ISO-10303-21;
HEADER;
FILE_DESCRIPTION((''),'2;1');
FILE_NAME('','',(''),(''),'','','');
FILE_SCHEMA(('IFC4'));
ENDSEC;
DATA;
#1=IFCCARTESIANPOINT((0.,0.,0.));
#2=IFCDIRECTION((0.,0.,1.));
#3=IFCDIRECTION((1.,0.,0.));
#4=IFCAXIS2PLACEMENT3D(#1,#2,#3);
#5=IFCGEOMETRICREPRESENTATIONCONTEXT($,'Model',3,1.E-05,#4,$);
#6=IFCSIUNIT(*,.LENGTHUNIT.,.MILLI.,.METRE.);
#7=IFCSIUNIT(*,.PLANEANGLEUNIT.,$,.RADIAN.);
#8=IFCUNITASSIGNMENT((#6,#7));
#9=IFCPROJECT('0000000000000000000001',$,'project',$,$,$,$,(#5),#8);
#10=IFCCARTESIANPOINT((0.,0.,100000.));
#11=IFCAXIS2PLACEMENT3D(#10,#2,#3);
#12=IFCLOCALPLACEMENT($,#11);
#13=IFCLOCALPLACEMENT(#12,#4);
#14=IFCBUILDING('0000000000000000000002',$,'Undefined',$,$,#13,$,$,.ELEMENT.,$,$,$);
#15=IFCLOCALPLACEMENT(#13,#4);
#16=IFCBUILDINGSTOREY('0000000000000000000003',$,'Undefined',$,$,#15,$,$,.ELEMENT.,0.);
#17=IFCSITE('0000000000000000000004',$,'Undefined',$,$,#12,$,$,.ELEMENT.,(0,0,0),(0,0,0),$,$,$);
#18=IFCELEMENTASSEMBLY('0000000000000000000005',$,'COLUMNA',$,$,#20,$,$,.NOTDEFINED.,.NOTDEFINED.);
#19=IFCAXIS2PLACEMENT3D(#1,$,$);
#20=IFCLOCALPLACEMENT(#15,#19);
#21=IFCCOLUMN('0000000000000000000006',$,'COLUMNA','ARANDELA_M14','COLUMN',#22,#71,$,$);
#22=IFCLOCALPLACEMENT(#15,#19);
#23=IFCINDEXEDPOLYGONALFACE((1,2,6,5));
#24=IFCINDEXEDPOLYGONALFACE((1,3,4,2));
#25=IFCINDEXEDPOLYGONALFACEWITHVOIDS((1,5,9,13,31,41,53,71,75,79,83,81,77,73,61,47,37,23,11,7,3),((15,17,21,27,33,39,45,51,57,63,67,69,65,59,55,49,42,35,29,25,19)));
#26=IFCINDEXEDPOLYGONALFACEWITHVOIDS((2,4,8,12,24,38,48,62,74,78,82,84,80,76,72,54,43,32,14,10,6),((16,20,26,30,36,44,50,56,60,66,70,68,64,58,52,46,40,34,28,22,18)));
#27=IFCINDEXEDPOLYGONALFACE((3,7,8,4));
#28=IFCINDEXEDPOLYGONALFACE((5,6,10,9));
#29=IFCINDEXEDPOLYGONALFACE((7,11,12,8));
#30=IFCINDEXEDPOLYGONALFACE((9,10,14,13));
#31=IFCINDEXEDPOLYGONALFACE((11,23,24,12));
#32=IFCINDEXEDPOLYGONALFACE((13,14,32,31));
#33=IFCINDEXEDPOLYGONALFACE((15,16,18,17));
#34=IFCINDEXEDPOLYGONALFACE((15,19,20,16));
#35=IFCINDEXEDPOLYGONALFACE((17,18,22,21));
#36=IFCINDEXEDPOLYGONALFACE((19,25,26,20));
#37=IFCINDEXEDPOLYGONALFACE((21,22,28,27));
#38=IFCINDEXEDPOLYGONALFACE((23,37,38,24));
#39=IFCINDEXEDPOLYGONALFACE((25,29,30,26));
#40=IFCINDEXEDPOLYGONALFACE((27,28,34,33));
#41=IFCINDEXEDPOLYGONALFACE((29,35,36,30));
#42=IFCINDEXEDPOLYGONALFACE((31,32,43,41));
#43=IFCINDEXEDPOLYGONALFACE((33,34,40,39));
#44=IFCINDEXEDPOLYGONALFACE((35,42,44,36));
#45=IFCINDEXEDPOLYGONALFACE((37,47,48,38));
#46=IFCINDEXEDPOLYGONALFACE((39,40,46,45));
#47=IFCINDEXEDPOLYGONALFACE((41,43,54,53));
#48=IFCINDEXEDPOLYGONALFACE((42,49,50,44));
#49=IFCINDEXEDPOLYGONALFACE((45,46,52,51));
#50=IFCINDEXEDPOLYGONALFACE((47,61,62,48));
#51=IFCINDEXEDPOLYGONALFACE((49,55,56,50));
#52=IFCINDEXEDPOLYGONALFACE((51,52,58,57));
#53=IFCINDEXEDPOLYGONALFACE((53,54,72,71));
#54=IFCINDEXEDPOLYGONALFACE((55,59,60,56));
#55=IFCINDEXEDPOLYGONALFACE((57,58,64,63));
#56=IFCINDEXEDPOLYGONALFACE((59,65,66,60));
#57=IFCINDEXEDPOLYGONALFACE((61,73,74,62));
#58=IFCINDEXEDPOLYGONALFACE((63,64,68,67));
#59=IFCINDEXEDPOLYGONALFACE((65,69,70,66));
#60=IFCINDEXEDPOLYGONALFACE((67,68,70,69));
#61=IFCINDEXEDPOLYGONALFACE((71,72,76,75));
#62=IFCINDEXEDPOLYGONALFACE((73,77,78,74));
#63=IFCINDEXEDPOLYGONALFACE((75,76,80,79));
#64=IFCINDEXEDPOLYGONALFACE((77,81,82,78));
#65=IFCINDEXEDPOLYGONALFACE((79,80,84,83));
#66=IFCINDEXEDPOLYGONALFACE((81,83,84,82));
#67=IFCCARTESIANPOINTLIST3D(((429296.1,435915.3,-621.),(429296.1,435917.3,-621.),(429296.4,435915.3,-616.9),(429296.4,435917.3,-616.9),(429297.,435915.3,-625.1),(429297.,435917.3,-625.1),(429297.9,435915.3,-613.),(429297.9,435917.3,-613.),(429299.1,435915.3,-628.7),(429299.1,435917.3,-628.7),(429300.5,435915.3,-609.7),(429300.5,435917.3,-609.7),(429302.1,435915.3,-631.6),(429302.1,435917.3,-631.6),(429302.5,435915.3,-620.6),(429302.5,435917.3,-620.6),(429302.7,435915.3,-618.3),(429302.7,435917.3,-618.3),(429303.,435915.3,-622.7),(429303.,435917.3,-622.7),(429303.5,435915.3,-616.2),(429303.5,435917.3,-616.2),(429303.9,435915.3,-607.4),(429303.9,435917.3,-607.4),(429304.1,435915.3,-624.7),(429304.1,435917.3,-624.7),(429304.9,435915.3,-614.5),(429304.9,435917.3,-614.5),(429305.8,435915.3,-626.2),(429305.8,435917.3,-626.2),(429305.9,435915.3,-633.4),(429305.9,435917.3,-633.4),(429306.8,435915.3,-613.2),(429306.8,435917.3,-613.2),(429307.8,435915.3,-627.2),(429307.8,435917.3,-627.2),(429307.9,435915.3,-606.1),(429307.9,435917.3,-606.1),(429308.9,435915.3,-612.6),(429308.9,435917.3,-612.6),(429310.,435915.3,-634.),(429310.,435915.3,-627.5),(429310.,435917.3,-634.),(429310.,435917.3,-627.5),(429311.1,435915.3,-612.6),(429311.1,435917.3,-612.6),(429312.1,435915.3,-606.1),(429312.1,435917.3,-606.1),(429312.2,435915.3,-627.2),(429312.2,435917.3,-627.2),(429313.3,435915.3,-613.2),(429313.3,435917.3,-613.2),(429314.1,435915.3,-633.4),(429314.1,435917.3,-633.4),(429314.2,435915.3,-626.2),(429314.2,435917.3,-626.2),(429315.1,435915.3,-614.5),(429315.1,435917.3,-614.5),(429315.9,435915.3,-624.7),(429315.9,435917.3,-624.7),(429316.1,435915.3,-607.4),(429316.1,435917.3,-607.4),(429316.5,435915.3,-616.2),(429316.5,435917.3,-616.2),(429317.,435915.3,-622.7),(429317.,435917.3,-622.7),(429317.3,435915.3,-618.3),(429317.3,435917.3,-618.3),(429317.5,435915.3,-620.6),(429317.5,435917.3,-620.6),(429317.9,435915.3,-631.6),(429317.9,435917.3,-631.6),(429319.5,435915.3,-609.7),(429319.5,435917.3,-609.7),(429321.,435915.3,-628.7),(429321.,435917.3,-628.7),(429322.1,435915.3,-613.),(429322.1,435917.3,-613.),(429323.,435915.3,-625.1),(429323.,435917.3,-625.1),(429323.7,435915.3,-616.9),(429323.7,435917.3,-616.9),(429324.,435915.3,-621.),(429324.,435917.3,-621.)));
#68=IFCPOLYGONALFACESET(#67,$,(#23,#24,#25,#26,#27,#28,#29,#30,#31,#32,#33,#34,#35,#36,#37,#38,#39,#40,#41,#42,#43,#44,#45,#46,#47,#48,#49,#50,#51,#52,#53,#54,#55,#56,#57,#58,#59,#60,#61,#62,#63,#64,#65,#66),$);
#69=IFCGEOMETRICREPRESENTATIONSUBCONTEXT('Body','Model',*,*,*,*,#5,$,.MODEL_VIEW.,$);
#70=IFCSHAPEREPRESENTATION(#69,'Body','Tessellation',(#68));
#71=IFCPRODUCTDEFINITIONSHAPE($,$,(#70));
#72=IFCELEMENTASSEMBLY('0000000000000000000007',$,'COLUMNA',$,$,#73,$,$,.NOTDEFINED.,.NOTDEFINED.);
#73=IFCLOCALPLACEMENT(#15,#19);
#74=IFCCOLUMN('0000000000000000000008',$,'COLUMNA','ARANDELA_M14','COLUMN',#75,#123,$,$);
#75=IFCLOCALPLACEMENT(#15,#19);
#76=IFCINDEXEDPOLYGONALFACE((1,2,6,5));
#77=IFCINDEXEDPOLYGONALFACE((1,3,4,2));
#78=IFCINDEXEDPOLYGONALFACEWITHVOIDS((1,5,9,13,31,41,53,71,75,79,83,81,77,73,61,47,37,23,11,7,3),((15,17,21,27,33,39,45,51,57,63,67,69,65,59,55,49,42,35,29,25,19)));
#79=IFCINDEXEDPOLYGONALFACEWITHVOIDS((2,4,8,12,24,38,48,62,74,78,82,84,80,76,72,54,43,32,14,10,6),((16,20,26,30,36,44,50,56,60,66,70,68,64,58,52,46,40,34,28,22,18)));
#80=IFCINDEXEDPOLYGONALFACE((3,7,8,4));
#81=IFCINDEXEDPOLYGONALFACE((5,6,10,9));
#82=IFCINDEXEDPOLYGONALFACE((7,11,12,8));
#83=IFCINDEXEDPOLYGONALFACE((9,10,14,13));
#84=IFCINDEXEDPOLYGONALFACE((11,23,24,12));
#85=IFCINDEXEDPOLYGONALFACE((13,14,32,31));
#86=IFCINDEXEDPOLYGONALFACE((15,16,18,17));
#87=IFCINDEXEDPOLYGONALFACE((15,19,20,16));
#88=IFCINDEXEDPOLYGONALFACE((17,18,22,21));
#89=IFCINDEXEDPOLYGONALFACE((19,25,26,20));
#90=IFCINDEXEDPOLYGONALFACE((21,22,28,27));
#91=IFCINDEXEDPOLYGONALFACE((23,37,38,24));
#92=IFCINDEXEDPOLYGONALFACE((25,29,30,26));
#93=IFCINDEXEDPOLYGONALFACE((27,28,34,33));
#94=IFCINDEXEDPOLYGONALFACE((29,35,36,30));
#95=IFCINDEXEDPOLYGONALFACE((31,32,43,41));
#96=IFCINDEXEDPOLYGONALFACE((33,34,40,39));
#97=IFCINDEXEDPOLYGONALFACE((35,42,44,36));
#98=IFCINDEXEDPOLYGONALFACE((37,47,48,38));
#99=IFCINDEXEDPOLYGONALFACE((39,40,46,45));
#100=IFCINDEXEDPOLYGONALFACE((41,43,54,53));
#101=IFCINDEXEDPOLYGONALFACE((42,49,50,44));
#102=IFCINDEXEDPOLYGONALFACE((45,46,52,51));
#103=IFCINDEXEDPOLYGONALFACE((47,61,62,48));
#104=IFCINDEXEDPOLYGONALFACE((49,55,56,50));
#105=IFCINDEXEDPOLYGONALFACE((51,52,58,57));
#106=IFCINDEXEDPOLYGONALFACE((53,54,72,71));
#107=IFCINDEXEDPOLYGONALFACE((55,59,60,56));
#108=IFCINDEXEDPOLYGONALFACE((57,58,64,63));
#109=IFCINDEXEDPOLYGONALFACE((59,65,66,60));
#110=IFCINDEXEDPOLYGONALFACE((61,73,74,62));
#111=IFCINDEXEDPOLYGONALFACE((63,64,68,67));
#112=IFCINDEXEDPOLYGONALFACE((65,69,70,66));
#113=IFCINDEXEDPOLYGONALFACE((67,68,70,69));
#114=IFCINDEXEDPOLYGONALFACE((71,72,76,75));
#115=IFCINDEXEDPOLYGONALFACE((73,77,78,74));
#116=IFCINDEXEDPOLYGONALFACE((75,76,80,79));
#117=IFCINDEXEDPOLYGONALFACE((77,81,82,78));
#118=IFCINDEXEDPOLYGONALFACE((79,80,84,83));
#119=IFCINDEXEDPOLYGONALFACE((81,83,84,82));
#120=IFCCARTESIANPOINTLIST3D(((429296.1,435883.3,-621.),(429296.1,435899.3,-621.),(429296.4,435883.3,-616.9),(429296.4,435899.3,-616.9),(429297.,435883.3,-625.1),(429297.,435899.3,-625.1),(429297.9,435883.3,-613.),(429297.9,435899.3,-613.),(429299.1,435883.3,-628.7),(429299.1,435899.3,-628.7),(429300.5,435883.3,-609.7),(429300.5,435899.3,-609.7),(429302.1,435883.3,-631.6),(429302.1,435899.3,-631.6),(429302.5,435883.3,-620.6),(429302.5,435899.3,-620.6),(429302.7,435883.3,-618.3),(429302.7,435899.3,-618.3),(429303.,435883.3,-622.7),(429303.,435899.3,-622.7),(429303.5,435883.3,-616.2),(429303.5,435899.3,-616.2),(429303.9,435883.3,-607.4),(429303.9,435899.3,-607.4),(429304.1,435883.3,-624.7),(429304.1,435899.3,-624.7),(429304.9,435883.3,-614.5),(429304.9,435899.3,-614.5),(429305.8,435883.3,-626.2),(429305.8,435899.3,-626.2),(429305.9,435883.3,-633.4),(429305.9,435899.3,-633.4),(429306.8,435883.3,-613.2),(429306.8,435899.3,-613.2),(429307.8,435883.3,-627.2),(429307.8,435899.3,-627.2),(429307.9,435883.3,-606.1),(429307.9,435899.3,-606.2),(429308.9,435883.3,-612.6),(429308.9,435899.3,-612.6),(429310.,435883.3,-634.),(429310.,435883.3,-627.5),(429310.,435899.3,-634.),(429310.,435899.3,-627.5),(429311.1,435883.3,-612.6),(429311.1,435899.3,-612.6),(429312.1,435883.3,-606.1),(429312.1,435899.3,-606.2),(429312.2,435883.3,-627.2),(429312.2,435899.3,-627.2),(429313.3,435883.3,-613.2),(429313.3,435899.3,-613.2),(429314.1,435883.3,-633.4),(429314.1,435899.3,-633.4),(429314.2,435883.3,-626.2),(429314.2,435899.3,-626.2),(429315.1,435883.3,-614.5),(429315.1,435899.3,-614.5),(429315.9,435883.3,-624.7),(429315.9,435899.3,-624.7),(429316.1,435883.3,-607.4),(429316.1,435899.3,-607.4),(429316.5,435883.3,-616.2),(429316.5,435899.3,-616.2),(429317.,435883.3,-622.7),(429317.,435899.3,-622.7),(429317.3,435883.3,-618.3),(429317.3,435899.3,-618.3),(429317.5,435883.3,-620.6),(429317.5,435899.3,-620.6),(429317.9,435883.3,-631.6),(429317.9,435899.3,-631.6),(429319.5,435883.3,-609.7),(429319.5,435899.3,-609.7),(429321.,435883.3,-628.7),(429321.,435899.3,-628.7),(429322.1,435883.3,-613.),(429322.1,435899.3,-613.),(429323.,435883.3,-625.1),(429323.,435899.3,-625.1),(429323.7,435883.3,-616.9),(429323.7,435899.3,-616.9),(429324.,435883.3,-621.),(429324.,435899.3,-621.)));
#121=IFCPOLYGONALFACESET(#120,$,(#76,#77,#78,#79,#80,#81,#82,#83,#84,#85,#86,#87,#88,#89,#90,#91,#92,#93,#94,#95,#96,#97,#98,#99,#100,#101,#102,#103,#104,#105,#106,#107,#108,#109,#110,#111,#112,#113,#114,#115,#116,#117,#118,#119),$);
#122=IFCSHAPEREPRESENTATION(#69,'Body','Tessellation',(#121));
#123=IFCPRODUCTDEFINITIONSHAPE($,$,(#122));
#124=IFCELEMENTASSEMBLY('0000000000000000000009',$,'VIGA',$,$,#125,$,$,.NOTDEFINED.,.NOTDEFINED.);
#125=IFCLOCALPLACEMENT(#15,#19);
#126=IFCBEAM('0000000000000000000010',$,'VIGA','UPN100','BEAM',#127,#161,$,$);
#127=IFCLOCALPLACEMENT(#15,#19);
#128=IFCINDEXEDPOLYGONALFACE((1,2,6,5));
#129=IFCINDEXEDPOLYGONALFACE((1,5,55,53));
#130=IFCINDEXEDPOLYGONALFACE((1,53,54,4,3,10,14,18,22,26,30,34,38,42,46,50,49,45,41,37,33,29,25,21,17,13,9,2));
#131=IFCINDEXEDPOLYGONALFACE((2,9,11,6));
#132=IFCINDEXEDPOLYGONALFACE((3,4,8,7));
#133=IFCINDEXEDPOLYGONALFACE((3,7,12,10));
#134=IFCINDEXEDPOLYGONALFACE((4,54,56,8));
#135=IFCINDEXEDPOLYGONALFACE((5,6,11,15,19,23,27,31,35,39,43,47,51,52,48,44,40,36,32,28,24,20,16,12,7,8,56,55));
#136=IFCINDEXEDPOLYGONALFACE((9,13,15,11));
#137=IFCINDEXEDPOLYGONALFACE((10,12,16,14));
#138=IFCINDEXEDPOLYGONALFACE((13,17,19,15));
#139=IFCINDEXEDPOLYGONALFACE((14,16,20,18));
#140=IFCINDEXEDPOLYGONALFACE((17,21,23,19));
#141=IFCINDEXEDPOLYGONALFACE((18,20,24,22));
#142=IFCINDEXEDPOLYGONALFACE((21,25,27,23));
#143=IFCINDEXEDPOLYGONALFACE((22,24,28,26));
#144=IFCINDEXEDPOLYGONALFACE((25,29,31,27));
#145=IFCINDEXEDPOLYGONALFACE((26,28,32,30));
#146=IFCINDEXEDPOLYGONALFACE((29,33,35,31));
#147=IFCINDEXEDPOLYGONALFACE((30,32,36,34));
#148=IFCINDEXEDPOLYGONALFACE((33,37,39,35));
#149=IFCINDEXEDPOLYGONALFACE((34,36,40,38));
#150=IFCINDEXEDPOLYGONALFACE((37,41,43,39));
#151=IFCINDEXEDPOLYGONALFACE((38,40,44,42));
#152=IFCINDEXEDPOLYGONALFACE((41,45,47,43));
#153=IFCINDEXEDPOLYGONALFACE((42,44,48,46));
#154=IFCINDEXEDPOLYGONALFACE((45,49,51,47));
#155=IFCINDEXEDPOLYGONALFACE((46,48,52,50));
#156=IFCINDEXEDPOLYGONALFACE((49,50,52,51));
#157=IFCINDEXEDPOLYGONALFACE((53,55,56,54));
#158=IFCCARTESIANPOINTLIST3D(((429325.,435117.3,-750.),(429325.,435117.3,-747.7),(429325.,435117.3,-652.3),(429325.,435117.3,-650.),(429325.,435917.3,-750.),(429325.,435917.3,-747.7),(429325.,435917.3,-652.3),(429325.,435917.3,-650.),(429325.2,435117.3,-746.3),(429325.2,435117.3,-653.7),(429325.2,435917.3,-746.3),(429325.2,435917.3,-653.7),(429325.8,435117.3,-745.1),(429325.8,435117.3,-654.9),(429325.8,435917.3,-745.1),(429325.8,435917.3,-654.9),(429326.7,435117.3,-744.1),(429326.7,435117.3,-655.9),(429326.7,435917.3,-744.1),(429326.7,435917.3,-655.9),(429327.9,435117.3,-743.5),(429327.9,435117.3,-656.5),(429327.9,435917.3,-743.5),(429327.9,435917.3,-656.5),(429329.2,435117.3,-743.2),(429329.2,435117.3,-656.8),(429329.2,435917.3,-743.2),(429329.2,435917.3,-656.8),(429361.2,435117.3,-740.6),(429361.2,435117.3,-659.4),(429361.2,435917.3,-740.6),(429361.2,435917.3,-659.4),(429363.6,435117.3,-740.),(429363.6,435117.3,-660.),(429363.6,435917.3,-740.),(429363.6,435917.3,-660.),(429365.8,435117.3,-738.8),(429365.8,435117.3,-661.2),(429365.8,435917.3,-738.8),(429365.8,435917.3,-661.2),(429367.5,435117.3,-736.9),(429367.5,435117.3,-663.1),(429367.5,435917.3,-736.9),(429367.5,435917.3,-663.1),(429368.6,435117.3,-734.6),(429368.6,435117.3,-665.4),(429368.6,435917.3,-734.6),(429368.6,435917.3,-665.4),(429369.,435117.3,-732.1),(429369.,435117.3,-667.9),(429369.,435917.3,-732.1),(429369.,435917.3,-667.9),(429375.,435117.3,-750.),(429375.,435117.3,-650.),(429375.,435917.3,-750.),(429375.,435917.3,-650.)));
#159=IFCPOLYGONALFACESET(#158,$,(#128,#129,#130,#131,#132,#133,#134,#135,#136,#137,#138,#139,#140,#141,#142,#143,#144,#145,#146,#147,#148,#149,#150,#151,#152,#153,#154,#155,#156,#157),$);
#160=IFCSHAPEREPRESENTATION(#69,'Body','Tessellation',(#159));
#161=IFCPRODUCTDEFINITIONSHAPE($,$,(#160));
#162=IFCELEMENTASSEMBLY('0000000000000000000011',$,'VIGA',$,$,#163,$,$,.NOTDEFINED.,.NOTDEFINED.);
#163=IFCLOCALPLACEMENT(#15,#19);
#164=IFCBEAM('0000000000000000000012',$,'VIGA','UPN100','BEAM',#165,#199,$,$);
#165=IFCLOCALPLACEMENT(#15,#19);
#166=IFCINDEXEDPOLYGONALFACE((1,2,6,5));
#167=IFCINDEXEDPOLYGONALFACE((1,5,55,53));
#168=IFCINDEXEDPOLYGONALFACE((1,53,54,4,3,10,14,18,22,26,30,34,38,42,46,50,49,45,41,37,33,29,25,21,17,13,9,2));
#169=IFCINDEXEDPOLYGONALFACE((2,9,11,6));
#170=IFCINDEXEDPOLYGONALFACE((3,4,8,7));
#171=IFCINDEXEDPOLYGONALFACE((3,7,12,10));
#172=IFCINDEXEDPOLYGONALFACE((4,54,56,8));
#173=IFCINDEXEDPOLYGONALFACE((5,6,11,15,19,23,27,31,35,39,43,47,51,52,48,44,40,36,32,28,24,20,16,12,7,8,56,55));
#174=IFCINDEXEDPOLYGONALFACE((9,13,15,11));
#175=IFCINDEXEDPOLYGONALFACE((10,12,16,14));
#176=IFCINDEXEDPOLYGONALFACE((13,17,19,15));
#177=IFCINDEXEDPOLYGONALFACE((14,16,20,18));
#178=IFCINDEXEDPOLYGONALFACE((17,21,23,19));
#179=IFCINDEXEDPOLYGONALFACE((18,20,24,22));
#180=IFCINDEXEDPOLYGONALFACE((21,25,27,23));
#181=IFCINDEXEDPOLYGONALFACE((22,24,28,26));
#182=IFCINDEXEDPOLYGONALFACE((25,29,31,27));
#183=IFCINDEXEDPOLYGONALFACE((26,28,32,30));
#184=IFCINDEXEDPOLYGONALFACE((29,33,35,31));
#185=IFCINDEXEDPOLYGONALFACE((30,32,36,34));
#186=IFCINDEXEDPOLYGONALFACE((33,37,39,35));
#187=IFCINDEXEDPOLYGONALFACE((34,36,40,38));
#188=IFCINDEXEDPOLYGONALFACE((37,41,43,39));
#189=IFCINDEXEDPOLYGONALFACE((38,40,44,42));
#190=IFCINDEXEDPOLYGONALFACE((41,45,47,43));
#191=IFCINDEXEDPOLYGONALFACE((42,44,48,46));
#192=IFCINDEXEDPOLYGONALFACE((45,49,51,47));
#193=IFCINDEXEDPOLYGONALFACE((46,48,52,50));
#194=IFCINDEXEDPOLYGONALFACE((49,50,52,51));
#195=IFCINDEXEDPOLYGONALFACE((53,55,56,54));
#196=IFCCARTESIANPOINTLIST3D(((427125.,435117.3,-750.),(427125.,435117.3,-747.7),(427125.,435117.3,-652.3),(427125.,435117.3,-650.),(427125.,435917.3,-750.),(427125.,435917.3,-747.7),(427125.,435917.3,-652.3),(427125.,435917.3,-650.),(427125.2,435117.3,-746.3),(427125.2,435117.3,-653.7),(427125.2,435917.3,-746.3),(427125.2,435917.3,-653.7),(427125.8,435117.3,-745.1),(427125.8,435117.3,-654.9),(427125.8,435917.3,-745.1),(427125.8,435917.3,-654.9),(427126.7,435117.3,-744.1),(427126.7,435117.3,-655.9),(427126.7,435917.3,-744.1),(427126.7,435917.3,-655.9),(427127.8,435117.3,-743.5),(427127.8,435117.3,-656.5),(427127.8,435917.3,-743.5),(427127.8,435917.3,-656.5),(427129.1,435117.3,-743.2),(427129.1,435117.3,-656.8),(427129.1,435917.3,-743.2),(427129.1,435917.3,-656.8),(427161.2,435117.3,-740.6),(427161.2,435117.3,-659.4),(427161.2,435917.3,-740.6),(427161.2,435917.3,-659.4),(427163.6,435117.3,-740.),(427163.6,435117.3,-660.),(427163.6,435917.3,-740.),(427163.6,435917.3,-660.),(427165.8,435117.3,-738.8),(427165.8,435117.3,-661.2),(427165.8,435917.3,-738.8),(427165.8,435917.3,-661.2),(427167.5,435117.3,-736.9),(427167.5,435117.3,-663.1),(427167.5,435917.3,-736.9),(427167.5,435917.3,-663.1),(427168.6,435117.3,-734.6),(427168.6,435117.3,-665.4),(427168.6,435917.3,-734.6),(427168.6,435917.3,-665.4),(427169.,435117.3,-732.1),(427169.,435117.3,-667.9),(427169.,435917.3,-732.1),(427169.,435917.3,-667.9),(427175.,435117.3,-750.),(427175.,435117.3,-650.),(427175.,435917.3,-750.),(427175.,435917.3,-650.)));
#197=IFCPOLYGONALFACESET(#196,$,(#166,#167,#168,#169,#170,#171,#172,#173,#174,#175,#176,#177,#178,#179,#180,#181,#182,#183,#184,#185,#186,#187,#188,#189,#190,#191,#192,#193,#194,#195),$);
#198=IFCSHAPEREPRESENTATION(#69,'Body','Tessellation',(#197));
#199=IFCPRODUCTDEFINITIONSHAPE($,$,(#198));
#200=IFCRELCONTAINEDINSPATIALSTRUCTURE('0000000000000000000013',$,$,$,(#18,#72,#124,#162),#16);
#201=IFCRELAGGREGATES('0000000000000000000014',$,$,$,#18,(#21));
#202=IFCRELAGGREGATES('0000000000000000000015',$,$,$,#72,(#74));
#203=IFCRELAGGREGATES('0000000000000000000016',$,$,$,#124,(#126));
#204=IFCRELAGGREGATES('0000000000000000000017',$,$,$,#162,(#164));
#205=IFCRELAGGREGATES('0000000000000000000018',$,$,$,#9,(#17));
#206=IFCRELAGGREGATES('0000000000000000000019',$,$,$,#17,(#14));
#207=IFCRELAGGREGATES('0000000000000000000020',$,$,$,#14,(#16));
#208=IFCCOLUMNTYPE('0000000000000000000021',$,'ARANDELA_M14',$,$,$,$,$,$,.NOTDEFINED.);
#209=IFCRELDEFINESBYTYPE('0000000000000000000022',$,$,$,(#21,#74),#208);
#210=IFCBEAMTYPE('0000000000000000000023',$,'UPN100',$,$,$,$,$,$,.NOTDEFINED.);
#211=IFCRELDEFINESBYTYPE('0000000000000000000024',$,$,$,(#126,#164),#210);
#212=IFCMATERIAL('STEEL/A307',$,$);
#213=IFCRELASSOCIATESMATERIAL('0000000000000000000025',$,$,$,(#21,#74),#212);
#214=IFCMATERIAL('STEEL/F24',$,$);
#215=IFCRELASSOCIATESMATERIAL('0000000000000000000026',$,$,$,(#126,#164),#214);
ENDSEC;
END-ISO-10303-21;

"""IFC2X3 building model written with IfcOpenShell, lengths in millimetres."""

from ifc_helpers import new_model, si_unit, frame, origin_with_axes, origin_2d_with_axis, place, context, subcontext, project, spatial, hollow_circle, u_section, extrude, material, type_object, element, aggregate, save


model = new_model("IFC2X3")

# Units and contexts
model_context = context("Model", 3, precision=1e-05, world=origin_with_axes())
body_context = subcontext(model_context, "Body", "Model", "MODEL_VIEW")
ifc_project = project(units=[si_unit("LENGTHUNIT", "METRE", prefix="MILLI"), si_unit("PLANEANGLEUNIT", "RADIAN")], contexts=[model_context])

# Site, building, storey
site_placement = place(None, frame((0.0, 0.0, 100000.0), z_axis=(0.0, 0.0, 1.0), x_axis=(1.0, 0.0, 0.0)))
site = spatial("IfcSite", under=ifc_project, at=site_placement, Name="Undefined", CompositionType="ELEMENT", RefLatitude=(0, 0, 0), RefLongitude=(0, 0, 0))
building_placement = place(site_placement, origin_with_axes())
building = spatial("IfcBuilding", under=site, at=building_placement, Name="Undefined", CompositionType="ELEMENT")
storey_placement = place(building_placement, origin_with_axes())
storey = spatial("IfcBuildingStorey", under=building, at=storey_placement, Name="Undefined", CompositionType="ELEMENT", Elevation=0.0)

# Element assemblies, columns
ifc_material_1 = material(Name="STEEL/A307")
column_type = type_object("IfcColumnType", Name="ARANDELA_M14", PredefinedType="NOTDEFINED")
assembly_1_placement = place(storey_placement, origin_with_axes())
assembly_1 = element("IfcElementAssembly", 1, at=assembly_1_placement, inside=storey, Name="COLUMNA", AssemblyPlace="NOTDEFINED", PredefinedType="NOTDEFINED")
column_1_placement = place(assembly_1_placement, frame((429310.0, 435917.3, -620.0), z_axis=(0.0, -1.0, 0.000285), x_axis=(-1.0, 0.0, 0.0)))
column_1 = element("IfcColumn", 2, at=column_1_placement, type_object=column_type, material=ifc_material_1, Name="COLUMNA", Description="ARANDELA_M14", ObjectType="COLUMN", context=body_context, shape_type="SweptSolid", body=[
    extrude(hollow_circle(Radius=14.0, WallThickness=6.5, at=origin_2d_with_axis()), frame((0.0, 0.0, 2.0), z_axis=(0.0, 0.0, -1.0), x_axis=(0.0, 1.0, 0.0)), (0.0, 0.0, 1.0), 2.0),
])
aggregate(assembly_1, [column_1])
assembly_2_placement = place(storey_placement, origin_with_axes())
assembly_2 = element("IfcElementAssembly", 3, at=assembly_2_placement, inside=storey, Name="COLUMNA", AssemblyPlace="NOTDEFINED", PredefinedType="NOTDEFINED")
column_2_placement = place(assembly_2_placement, frame((429310.0, 435899.3, -620.0), z_axis=(0.0, -1.0, 0.000285), x_axis=(-1.0, 0.0, 0.0)))
column_2 = element("IfcColumn", 4, at=column_2_placement, type_object=column_type, material=ifc_material_1, Name="COLUMNA", Description="ARANDELA_M14", ObjectType="COLUMN", context=body_context, shape_type="SweptSolid", body=[
    extrude(hollow_circle(Radius=14.0, WallThickness=6.5, at=origin_2d_with_axis()), frame((0.0, 0.0, 16.0), z_axis=(0.0, 0.0, -1.0), x_axis=(0.0, 1.0, 0.0)), (0.0, 0.0, 1.0), 16.0),
])
aggregate(assembly_2, [column_2])

# Element assemblies, beams
assembly_3_placement = place(storey_placement, origin_with_axes())
assembly_3 = element("IfcElementAssembly", 5, at=assembly_3_placement, inside=storey, Name="VIGA", AssemblyPlace="NOTDEFINED", PredefinedType="NOTDEFINED")
ifc_material_2 = material(Name="STEEL/F24")
beam_type = type_object("IfcBeamType", Name="UPN100", PredefinedType="NOTDEFINED")
beam_1_placement = place(assembly_3_placement, frame((429350.0, 435917.3, -700.0), z_axis=(0.0, 0.0, 1.0), x_axis=(0.0, -1.0, 0.0)))
beam_1 = element("IfcBeam", 6, at=beam_1_placement, type_object=beam_type, material=ifc_material_2, Name="VIGA", Description="UPN100", ObjectType="BEAM", context=body_context, shape_type="SweptSolid", body=[
    extrude(u_section(Depth=100.0, FlangeWidth=50.0, WebThickness=6.0, FlangeThickness=8.5, FilletRadius=8.5, EdgeRadius=4.5, FlangeSlope=0.07983, at=origin_2d_with_axis()), frame((800.0, 0.0, 0.0), z_axis=(-1.0, 0.0, 0.0), x_axis=(0.0, -1.0, 0.0)), (0.0, 0.0, 1.0), 800.0),
])
aggregate(assembly_3, [beam_1])
assembly_4_placement = place(storey_placement, origin_with_axes())
assembly_4 = element("IfcElementAssembly", 7, at=assembly_4_placement, inside=storey, Name="VIGA", AssemblyPlace="NOTDEFINED", PredefinedType="NOTDEFINED")
beam_2_placement = place(assembly_4_placement, frame((427150.0, 435917.3, -700.0), z_axis=(0.0, 0.0, 1.0), x_axis=(0.0, -1.0, 0.0)))
beam_2 = element("IfcBeam", 8, at=beam_2_placement, type_object=beam_type, material=ifc_material_2, Name="VIGA", Description="UPN100", ObjectType="BEAM", context=body_context, shape_type="SweptSolid", body=[
    extrude(u_section(Depth=100.0, FlangeWidth=50.0, WebThickness=6.0, FlangeThickness=8.5, FilletRadius=8.5, EdgeRadius=4.5, FlangeSlope=0.07983, at=origin_2d_with_axis()), frame((800.0, 0.0, 0.0), z_axis=(-1.0, 0.0, 0.0), x_axis=(0.0, -1.0, 0.0)), (0.0, 0.0, 1.0), 800.0),
])
aggregate(assembly_4, [beam_2])

save(model, "model.ifc")
